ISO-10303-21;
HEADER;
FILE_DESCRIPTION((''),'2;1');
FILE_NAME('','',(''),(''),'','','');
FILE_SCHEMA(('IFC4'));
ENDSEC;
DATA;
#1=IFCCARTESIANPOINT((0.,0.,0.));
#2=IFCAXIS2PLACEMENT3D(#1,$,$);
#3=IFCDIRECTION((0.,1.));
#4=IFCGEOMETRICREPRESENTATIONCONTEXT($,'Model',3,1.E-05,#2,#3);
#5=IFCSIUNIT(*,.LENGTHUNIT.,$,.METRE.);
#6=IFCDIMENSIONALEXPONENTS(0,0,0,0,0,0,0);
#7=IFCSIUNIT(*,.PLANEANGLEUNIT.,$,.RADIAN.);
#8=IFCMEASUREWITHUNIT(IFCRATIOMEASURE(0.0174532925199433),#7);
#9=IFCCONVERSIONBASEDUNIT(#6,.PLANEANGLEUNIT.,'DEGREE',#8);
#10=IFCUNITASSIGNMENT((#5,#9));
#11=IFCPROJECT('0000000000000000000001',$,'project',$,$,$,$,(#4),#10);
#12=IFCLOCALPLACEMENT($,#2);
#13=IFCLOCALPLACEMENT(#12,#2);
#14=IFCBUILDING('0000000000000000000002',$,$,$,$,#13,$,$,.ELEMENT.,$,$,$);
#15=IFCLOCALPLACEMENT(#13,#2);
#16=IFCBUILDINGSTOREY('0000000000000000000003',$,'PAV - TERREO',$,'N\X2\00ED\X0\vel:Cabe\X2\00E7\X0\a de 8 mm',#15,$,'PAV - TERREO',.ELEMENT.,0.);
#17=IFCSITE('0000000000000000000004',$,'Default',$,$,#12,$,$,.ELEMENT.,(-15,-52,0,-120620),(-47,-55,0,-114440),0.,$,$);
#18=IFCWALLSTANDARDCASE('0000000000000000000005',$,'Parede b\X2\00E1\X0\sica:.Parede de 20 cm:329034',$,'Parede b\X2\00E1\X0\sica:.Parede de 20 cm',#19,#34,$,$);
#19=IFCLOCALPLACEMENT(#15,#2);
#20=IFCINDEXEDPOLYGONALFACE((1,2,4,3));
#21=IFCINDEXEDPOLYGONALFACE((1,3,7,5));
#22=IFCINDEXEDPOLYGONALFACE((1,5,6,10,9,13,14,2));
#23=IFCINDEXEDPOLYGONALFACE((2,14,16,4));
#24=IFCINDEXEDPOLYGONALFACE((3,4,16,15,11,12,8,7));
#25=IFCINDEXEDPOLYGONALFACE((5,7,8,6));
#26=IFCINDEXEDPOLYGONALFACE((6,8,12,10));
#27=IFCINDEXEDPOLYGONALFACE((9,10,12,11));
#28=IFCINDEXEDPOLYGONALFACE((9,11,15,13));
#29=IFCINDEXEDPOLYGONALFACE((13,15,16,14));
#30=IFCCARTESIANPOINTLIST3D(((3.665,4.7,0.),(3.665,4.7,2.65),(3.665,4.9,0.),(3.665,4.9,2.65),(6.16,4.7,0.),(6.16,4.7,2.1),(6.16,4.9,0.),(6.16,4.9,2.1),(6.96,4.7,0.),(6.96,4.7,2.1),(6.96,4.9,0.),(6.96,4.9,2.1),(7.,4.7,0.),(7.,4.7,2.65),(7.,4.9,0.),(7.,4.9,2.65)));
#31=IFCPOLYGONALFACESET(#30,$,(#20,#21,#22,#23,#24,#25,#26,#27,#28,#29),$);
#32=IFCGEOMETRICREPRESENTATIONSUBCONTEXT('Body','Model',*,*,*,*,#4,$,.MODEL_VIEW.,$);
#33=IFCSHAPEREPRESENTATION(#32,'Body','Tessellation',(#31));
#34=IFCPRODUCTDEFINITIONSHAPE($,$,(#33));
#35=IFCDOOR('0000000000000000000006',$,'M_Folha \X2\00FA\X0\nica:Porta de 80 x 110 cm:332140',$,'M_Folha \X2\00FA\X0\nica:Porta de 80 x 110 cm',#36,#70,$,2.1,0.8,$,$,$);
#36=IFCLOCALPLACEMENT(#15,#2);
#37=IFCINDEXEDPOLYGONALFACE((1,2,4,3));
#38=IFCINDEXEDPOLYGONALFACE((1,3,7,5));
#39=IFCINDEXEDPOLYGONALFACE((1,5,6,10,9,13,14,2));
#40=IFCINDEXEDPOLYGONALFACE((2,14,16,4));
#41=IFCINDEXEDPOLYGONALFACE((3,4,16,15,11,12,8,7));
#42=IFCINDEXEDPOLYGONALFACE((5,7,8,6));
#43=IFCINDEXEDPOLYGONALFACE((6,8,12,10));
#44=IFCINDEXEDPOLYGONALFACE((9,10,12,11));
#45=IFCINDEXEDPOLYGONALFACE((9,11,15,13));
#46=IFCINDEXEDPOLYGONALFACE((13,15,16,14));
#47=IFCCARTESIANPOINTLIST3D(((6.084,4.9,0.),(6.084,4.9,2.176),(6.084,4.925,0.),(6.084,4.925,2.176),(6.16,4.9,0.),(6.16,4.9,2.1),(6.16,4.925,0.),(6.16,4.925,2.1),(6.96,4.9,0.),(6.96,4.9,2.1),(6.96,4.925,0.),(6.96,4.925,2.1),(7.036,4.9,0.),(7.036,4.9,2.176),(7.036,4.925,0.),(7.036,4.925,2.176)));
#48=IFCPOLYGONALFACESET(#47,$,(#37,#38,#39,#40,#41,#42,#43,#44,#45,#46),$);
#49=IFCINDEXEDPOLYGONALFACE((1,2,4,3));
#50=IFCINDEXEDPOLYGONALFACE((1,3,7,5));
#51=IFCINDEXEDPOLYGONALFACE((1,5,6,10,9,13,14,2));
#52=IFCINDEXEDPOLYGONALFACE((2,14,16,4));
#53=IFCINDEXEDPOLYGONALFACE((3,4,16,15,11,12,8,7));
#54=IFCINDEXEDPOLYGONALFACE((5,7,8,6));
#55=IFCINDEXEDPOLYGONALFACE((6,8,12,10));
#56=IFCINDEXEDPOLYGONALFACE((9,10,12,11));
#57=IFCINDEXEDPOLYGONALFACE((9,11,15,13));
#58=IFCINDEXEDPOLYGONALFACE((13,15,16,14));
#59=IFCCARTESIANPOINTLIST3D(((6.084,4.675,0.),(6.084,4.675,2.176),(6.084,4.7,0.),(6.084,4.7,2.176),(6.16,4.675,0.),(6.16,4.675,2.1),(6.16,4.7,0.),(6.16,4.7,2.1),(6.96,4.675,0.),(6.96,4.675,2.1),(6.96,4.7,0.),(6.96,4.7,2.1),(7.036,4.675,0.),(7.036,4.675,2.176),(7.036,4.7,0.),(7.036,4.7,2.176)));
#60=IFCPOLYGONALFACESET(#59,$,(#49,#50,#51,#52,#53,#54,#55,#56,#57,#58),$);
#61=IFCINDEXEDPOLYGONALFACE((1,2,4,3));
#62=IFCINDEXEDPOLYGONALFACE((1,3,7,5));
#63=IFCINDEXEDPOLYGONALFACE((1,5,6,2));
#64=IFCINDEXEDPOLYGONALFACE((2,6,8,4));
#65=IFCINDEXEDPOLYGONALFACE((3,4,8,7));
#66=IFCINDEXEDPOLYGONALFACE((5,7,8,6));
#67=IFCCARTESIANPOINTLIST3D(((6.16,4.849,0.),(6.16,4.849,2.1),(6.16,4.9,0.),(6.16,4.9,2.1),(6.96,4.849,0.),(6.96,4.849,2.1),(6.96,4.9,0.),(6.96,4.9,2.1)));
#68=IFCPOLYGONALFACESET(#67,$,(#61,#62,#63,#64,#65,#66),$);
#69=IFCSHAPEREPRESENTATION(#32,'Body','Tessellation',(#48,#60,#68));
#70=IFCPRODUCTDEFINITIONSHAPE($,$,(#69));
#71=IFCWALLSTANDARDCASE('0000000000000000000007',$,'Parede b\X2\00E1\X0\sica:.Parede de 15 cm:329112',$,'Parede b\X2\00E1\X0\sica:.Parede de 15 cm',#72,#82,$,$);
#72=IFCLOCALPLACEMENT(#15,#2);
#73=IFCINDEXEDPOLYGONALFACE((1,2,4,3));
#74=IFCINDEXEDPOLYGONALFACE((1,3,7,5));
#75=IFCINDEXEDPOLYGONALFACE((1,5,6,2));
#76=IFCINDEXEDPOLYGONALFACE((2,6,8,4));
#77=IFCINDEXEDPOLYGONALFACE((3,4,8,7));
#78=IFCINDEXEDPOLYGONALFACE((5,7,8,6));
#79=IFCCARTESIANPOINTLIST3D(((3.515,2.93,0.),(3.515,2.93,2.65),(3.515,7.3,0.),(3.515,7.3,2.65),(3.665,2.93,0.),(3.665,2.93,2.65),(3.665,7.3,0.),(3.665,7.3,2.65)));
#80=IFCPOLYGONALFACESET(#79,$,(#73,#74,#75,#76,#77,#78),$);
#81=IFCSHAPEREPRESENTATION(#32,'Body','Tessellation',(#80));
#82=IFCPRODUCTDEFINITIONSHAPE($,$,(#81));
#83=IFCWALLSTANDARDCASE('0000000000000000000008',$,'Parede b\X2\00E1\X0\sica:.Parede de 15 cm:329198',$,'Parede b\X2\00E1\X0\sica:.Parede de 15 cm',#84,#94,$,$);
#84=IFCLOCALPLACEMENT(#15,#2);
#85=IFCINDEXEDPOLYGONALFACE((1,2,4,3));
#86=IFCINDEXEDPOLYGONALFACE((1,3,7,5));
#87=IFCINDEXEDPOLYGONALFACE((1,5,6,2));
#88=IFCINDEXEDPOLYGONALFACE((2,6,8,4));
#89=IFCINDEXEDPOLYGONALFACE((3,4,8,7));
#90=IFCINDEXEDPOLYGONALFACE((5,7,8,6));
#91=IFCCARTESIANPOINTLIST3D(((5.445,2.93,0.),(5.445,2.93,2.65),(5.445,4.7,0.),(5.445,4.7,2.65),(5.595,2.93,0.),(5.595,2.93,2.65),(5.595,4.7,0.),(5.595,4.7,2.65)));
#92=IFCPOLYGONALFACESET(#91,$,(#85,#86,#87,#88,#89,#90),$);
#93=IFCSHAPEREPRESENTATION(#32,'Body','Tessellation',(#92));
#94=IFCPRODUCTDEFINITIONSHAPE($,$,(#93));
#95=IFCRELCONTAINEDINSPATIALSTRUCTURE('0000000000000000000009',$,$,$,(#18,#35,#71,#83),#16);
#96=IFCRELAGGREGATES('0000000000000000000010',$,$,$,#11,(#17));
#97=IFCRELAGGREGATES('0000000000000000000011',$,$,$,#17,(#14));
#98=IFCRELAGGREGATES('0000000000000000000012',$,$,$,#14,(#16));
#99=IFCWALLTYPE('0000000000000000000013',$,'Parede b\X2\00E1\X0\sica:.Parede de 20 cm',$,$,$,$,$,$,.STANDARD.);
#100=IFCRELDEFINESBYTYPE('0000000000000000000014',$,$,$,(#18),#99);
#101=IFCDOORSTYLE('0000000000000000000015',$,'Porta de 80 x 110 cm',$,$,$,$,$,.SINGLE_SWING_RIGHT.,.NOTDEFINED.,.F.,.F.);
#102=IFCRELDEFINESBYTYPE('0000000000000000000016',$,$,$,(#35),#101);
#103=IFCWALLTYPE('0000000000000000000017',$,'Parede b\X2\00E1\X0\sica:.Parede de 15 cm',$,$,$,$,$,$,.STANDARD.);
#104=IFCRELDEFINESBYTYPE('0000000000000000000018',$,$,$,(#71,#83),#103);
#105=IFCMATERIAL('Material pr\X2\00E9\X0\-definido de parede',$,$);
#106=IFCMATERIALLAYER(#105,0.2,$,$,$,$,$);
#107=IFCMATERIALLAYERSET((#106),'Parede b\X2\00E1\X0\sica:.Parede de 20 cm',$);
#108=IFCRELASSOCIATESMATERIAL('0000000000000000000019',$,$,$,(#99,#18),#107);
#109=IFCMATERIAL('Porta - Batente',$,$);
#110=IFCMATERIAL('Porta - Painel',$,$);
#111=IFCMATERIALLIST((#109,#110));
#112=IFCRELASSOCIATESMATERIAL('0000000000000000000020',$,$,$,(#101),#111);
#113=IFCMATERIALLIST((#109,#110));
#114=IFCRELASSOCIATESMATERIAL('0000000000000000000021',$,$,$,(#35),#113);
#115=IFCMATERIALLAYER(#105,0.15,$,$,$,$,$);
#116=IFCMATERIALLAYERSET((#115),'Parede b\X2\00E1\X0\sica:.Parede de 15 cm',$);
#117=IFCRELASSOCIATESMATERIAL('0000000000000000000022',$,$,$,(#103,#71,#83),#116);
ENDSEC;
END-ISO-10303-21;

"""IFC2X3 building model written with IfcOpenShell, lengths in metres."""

from ifc_helpers import new_model, entity, si_unit, converted_unit, direction, frame, frame_2d, origin, place, context, subcontext, project, spatial, polyline, rectangle, outline, extrude, clip, bounded_halfspace, source, transform, mapped, material, material_list, layer, layer_set, layer_usage, type_object, type_shapes, element, fill, save


model = new_model("IFC2X3")

# Units and contexts
model_context = context("Model", 3, precision=1e-05, world=origin(), true_north=direction((0.0, 1.0)))
body_context = subcontext(model_context, "Body", "Model", "MODEL_VIEW")
ifc_project = project(units=[si_unit("LENGTHUNIT", "METRE"), converted_unit("PLANEANGLEUNIT", "DEGREE", entity("IfcRatioMeasure", 0.0174532925199433), si_unit("PLANEANGLEUNIT", "RADIAN"), dimensions=[0, 0, 0, 0, 0, 0, 0])], contexts=[model_context])

# Site, building, storey
site_placement = place(None, origin())
site = spatial("IfcSite", under=ifc_project, at=site_placement, Name="Default", CompositionType="ELEMENT", RefLatitude=(-15, -52, 0, -120620), RefLongitude=(-47, -55, 0, -114440), RefElevation=0.0)
building_placement = place(site_placement, origin())
building = spatial("IfcBuilding", under=site, at=building_placement, CompositionType="ELEMENT")
storey_placement = place(building_placement, origin())
storey = spatial("IfcBuildingStorey", under=building, at=storey_placement, Name="PAV - TERREO", ObjectType="Nível:Cabeça de 8 mm", LongName="PAV - TERREO", CompositionType="ELEMENT", Elevation=0.0)

# Shared definitions
ifc_material_1 = material(Name="Material pré-definido de parede")
ifc_layer_1 = layer(ifc_material_1, 0.2)
ifc_layer_set_1 = layer_set([ifc_layer_1], Name="Parede básica:.Parede de 20 cm")
wall_type_1 = type_object("IfcWallType", Name="Parede básica:.Parede de 20 cm", PredefinedType="STANDARD", material=ifc_layer_set_1)
ifc_material_2 = material(Name="Porta - Batente")
ifc_material_3 = material(Name="Porta - Painel")
ifc_material_list_1 = material_list([ifc_material_2, ifc_material_3])
door_style_1 = type_object("IfcDoorStyle", Name="Porta de 80 x 110 cm", ConstructionType="NOTDEFINED", OperationType="SINGLE_SWING_RIGHT", ParameterTakesPrecedence=False, Sizeable=False, material=ifc_material_list_1)
shared_shape_1 = source(origin(), body_context, "Body", "SweptSolid", [
    extrude(outline(polyline([(-0.476, -1.107), (0.476, -1.107), (0.476, 1.069), (0.4, 1.069), (0.4, -1.031), (-0.4, -1.031), (-0.4, 1.069), (-0.476, 1.069), (-0.476, -1.107)])), frame((0.4, 0.2, 1.069), z_axis=(0.0, 1.0, 0.0), x_axis=(1.0, 0.0, 0.0)), (0.0, 0.0, 1.0), 0.025),
    extrude(outline(polyline([(-1.107, -0.476), (1.069, -0.476), (1.069, -0.4), (-1.031, -0.4), (-1.031, 0.4), (1.069, 0.4), (1.069, 0.476), (-1.107, 0.476), (-1.107, -0.476)])), frame((0.4, -0.025, 1.069), z_axis=(0.0, 1.0, 0.0), x_axis=(0.0, 0.0, -1.0)), (0.0, 0.0, 1.0), 0.025),
    extrude(rectangle(XDim=0.051, YDim=0.8, at=frame_2d((0.0, 0.0), x_axis=(1.0, 0.0))), frame((0.4, 0.1745, 0.0), z_axis=(0.0, 0.0, 1.0), x_axis=(0.0, 1.0, 0.0)), (0.0, 0.0, 1.0), 2.1),
])
type_shapes(door_style_1, [shared_shape_1])

# Wall, opening, door
ifc_layer_usage_1 = layer_usage(ifc_layer_set_1, "AXIS2", "NEGATIVE", 0.1)
wall_1_placement = place(storey_placement, frame((7.0, 4.8, 0.0), z_axis=(0.0, 0.0, 1.0), x_axis=(-1.0, 0.0, 0.0)))
wall_1 = element("IfcWallStandardCase", 1, at=wall_1_placement, inside=storey, type_object=wall_type_1, material=ifc_layer_usage_1, Name="Parede básica:.Parede de 20 cm:329034", ObjectType="Parede básica:.Parede de 20 cm", context=body_context, shape_type="Clipping", body=[
    clip(extrude(rectangle(XDim=3.335, YDim=0.2, at=frame_2d((1.6675, 0.0), x_axis=(-1.0, 0.0))), origin(), (0.0, 0.0, 1.0), 2.65), bounded_halfspace(frame((0.0, -0.1, 2.65), z_axis=(0.0, 0.0, -1.0), x_axis=(0.0, 1.0, 0.0)), True, frame((0.0, -0.1, 2.65)), polyline([(0.0, 0.0), (3.335, 0.0), (3.335, 0.2), (1.555, 0.2), (1.405, 0.2), (0.0, 0.2), (0.0, 0.0)]))),
])
opening_1_placement = place(wall_1_placement, frame((0.84, 0.1, 0.0)))
opening_1 = element("IfcOpeningElement", 2, at=opening_1_placement, cuts=wall_1, ObjectType="Opening", context=body_context, shape_type="SweptSolid", body=[
    extrude(rectangle(XDim=0.8, YDim=2.1, at=frame_2d((1.05, 0.4), x_axis=(0.0, 1.0))), frame((0.0, 0.0, 0.0), z_axis=(0.0, -1.0, 0.0), x_axis=(0.0, 0.0, 1.0)), (0.0, 0.0, 1.0), 0.2),
])
ifc_material_list_2 = material_list([ifc_material_2, ifc_material_3])
door_1_placement = place(opening_1_placement, frame((0.0, 0.0, 0.0), z_axis=(0.0, 0.0, 1.0), x_axis=(-1.0, 0.0, 0.0)))
door_1 = element("IfcDoor", 3, at=door_1_placement, inside=storey, type_object=door_style_1, material=ifc_material_list_2, Name="M_Folha única:Porta de 80 x 110 cm:332140", ObjectType="M_Folha única:Porta de 80 x 110 cm", OverallHeight=2.1, OverallWidth=0.8, context=body_context, shape_type="MappedRepresentation", body=[
    mapped(shared_shape_1, transform((0.0, 0.0, 0.0), scale=1.0)),
])
fill(opening_1, door_1)

# Walls
ifc_layer_2 = layer(ifc_material_1, 0.15)
ifc_layer_set_2 = layer_set([ifc_layer_2], Name="Parede básica:.Parede de 15 cm")
ifc_layer_usage_2 = layer_usage(ifc_layer_set_2, "AXIS2", "NEGATIVE", 0.075)
wall_type_2 = type_object("IfcWallType", Name="Parede básica:.Parede de 15 cm", PredefinedType="STANDARD", material=ifc_layer_set_2)
wall_2_placement = place(storey_placement, frame((3.59, 2.93, 0.0), z_axis=(0.0, 0.0, 1.0), x_axis=(0.0, 1.0, 0.0)))
element("IfcWallStandardCase", 4, at=wall_2_placement, inside=storey, type_object=wall_type_2, material=ifc_layer_usage_2, Name="Parede básica:.Parede de 15 cm:329112", ObjectType="Parede básica:.Parede de 15 cm", context=body_context, shape_type="Clipping", body=[
    clip(extrude(rectangle(XDim=4.37, YDim=0.15, at=frame_2d((2.185, 0.0), x_axis=(-1.0, 0.0))), origin(), (0.0, 0.0, 1.0), 2.65), bounded_halfspace(frame((0.0, -0.075, 2.65), z_axis=(0.0, 0.0, -1.0), x_axis=(-1.0, 0.0, 0.0)), True, frame((0.0, -0.075, 2.65)), polyline([(0.0, 0.0), (1.77, 0.0), (1.97, 0.0), (4.37, 0.0), (4.37, 0.15), (0.0, 0.15), (0.0, 0.0)]))),
])
ifc_layer_usage_3 = layer_usage(ifc_layer_set_2, "AXIS2", "NEGATIVE", 0.075)
wall_3_placement = place(storey_placement, frame((5.52, 2.93, 0.0), z_axis=(0.0, 0.0, 1.0), x_axis=(0.0, 1.0, 0.0)))
element("IfcWallStandardCase", 5, at=wall_3_placement, inside=storey, type_object=wall_type_2, material=ifc_layer_usage_3, Name="Parede básica:.Parede de 15 cm:329198", ObjectType="Parede básica:.Parede de 15 cm", context=body_context, shape_type="Clipping", body=[
    clip(extrude(rectangle(XDim=1.77, YDim=0.15, at=frame_2d((0.885, 0.0), x_axis=(-1.0, 0.0))), origin(), (0.0, 0.0, 1.0), 2.65), bounded_halfspace(frame((0.0, -0.075, 2.65), z_axis=(0.0, 0.0, -1.0), x_axis=(-1.0, 0.0, 0.0)), True, frame((0.0, -0.075, 2.65)), polyline([(0.0, 0.0), (1.77, 0.0), (1.77, 0.15), (0.0, 0.15), (0.0, 0.0)]))),
])

save(model, "model.ifc")
